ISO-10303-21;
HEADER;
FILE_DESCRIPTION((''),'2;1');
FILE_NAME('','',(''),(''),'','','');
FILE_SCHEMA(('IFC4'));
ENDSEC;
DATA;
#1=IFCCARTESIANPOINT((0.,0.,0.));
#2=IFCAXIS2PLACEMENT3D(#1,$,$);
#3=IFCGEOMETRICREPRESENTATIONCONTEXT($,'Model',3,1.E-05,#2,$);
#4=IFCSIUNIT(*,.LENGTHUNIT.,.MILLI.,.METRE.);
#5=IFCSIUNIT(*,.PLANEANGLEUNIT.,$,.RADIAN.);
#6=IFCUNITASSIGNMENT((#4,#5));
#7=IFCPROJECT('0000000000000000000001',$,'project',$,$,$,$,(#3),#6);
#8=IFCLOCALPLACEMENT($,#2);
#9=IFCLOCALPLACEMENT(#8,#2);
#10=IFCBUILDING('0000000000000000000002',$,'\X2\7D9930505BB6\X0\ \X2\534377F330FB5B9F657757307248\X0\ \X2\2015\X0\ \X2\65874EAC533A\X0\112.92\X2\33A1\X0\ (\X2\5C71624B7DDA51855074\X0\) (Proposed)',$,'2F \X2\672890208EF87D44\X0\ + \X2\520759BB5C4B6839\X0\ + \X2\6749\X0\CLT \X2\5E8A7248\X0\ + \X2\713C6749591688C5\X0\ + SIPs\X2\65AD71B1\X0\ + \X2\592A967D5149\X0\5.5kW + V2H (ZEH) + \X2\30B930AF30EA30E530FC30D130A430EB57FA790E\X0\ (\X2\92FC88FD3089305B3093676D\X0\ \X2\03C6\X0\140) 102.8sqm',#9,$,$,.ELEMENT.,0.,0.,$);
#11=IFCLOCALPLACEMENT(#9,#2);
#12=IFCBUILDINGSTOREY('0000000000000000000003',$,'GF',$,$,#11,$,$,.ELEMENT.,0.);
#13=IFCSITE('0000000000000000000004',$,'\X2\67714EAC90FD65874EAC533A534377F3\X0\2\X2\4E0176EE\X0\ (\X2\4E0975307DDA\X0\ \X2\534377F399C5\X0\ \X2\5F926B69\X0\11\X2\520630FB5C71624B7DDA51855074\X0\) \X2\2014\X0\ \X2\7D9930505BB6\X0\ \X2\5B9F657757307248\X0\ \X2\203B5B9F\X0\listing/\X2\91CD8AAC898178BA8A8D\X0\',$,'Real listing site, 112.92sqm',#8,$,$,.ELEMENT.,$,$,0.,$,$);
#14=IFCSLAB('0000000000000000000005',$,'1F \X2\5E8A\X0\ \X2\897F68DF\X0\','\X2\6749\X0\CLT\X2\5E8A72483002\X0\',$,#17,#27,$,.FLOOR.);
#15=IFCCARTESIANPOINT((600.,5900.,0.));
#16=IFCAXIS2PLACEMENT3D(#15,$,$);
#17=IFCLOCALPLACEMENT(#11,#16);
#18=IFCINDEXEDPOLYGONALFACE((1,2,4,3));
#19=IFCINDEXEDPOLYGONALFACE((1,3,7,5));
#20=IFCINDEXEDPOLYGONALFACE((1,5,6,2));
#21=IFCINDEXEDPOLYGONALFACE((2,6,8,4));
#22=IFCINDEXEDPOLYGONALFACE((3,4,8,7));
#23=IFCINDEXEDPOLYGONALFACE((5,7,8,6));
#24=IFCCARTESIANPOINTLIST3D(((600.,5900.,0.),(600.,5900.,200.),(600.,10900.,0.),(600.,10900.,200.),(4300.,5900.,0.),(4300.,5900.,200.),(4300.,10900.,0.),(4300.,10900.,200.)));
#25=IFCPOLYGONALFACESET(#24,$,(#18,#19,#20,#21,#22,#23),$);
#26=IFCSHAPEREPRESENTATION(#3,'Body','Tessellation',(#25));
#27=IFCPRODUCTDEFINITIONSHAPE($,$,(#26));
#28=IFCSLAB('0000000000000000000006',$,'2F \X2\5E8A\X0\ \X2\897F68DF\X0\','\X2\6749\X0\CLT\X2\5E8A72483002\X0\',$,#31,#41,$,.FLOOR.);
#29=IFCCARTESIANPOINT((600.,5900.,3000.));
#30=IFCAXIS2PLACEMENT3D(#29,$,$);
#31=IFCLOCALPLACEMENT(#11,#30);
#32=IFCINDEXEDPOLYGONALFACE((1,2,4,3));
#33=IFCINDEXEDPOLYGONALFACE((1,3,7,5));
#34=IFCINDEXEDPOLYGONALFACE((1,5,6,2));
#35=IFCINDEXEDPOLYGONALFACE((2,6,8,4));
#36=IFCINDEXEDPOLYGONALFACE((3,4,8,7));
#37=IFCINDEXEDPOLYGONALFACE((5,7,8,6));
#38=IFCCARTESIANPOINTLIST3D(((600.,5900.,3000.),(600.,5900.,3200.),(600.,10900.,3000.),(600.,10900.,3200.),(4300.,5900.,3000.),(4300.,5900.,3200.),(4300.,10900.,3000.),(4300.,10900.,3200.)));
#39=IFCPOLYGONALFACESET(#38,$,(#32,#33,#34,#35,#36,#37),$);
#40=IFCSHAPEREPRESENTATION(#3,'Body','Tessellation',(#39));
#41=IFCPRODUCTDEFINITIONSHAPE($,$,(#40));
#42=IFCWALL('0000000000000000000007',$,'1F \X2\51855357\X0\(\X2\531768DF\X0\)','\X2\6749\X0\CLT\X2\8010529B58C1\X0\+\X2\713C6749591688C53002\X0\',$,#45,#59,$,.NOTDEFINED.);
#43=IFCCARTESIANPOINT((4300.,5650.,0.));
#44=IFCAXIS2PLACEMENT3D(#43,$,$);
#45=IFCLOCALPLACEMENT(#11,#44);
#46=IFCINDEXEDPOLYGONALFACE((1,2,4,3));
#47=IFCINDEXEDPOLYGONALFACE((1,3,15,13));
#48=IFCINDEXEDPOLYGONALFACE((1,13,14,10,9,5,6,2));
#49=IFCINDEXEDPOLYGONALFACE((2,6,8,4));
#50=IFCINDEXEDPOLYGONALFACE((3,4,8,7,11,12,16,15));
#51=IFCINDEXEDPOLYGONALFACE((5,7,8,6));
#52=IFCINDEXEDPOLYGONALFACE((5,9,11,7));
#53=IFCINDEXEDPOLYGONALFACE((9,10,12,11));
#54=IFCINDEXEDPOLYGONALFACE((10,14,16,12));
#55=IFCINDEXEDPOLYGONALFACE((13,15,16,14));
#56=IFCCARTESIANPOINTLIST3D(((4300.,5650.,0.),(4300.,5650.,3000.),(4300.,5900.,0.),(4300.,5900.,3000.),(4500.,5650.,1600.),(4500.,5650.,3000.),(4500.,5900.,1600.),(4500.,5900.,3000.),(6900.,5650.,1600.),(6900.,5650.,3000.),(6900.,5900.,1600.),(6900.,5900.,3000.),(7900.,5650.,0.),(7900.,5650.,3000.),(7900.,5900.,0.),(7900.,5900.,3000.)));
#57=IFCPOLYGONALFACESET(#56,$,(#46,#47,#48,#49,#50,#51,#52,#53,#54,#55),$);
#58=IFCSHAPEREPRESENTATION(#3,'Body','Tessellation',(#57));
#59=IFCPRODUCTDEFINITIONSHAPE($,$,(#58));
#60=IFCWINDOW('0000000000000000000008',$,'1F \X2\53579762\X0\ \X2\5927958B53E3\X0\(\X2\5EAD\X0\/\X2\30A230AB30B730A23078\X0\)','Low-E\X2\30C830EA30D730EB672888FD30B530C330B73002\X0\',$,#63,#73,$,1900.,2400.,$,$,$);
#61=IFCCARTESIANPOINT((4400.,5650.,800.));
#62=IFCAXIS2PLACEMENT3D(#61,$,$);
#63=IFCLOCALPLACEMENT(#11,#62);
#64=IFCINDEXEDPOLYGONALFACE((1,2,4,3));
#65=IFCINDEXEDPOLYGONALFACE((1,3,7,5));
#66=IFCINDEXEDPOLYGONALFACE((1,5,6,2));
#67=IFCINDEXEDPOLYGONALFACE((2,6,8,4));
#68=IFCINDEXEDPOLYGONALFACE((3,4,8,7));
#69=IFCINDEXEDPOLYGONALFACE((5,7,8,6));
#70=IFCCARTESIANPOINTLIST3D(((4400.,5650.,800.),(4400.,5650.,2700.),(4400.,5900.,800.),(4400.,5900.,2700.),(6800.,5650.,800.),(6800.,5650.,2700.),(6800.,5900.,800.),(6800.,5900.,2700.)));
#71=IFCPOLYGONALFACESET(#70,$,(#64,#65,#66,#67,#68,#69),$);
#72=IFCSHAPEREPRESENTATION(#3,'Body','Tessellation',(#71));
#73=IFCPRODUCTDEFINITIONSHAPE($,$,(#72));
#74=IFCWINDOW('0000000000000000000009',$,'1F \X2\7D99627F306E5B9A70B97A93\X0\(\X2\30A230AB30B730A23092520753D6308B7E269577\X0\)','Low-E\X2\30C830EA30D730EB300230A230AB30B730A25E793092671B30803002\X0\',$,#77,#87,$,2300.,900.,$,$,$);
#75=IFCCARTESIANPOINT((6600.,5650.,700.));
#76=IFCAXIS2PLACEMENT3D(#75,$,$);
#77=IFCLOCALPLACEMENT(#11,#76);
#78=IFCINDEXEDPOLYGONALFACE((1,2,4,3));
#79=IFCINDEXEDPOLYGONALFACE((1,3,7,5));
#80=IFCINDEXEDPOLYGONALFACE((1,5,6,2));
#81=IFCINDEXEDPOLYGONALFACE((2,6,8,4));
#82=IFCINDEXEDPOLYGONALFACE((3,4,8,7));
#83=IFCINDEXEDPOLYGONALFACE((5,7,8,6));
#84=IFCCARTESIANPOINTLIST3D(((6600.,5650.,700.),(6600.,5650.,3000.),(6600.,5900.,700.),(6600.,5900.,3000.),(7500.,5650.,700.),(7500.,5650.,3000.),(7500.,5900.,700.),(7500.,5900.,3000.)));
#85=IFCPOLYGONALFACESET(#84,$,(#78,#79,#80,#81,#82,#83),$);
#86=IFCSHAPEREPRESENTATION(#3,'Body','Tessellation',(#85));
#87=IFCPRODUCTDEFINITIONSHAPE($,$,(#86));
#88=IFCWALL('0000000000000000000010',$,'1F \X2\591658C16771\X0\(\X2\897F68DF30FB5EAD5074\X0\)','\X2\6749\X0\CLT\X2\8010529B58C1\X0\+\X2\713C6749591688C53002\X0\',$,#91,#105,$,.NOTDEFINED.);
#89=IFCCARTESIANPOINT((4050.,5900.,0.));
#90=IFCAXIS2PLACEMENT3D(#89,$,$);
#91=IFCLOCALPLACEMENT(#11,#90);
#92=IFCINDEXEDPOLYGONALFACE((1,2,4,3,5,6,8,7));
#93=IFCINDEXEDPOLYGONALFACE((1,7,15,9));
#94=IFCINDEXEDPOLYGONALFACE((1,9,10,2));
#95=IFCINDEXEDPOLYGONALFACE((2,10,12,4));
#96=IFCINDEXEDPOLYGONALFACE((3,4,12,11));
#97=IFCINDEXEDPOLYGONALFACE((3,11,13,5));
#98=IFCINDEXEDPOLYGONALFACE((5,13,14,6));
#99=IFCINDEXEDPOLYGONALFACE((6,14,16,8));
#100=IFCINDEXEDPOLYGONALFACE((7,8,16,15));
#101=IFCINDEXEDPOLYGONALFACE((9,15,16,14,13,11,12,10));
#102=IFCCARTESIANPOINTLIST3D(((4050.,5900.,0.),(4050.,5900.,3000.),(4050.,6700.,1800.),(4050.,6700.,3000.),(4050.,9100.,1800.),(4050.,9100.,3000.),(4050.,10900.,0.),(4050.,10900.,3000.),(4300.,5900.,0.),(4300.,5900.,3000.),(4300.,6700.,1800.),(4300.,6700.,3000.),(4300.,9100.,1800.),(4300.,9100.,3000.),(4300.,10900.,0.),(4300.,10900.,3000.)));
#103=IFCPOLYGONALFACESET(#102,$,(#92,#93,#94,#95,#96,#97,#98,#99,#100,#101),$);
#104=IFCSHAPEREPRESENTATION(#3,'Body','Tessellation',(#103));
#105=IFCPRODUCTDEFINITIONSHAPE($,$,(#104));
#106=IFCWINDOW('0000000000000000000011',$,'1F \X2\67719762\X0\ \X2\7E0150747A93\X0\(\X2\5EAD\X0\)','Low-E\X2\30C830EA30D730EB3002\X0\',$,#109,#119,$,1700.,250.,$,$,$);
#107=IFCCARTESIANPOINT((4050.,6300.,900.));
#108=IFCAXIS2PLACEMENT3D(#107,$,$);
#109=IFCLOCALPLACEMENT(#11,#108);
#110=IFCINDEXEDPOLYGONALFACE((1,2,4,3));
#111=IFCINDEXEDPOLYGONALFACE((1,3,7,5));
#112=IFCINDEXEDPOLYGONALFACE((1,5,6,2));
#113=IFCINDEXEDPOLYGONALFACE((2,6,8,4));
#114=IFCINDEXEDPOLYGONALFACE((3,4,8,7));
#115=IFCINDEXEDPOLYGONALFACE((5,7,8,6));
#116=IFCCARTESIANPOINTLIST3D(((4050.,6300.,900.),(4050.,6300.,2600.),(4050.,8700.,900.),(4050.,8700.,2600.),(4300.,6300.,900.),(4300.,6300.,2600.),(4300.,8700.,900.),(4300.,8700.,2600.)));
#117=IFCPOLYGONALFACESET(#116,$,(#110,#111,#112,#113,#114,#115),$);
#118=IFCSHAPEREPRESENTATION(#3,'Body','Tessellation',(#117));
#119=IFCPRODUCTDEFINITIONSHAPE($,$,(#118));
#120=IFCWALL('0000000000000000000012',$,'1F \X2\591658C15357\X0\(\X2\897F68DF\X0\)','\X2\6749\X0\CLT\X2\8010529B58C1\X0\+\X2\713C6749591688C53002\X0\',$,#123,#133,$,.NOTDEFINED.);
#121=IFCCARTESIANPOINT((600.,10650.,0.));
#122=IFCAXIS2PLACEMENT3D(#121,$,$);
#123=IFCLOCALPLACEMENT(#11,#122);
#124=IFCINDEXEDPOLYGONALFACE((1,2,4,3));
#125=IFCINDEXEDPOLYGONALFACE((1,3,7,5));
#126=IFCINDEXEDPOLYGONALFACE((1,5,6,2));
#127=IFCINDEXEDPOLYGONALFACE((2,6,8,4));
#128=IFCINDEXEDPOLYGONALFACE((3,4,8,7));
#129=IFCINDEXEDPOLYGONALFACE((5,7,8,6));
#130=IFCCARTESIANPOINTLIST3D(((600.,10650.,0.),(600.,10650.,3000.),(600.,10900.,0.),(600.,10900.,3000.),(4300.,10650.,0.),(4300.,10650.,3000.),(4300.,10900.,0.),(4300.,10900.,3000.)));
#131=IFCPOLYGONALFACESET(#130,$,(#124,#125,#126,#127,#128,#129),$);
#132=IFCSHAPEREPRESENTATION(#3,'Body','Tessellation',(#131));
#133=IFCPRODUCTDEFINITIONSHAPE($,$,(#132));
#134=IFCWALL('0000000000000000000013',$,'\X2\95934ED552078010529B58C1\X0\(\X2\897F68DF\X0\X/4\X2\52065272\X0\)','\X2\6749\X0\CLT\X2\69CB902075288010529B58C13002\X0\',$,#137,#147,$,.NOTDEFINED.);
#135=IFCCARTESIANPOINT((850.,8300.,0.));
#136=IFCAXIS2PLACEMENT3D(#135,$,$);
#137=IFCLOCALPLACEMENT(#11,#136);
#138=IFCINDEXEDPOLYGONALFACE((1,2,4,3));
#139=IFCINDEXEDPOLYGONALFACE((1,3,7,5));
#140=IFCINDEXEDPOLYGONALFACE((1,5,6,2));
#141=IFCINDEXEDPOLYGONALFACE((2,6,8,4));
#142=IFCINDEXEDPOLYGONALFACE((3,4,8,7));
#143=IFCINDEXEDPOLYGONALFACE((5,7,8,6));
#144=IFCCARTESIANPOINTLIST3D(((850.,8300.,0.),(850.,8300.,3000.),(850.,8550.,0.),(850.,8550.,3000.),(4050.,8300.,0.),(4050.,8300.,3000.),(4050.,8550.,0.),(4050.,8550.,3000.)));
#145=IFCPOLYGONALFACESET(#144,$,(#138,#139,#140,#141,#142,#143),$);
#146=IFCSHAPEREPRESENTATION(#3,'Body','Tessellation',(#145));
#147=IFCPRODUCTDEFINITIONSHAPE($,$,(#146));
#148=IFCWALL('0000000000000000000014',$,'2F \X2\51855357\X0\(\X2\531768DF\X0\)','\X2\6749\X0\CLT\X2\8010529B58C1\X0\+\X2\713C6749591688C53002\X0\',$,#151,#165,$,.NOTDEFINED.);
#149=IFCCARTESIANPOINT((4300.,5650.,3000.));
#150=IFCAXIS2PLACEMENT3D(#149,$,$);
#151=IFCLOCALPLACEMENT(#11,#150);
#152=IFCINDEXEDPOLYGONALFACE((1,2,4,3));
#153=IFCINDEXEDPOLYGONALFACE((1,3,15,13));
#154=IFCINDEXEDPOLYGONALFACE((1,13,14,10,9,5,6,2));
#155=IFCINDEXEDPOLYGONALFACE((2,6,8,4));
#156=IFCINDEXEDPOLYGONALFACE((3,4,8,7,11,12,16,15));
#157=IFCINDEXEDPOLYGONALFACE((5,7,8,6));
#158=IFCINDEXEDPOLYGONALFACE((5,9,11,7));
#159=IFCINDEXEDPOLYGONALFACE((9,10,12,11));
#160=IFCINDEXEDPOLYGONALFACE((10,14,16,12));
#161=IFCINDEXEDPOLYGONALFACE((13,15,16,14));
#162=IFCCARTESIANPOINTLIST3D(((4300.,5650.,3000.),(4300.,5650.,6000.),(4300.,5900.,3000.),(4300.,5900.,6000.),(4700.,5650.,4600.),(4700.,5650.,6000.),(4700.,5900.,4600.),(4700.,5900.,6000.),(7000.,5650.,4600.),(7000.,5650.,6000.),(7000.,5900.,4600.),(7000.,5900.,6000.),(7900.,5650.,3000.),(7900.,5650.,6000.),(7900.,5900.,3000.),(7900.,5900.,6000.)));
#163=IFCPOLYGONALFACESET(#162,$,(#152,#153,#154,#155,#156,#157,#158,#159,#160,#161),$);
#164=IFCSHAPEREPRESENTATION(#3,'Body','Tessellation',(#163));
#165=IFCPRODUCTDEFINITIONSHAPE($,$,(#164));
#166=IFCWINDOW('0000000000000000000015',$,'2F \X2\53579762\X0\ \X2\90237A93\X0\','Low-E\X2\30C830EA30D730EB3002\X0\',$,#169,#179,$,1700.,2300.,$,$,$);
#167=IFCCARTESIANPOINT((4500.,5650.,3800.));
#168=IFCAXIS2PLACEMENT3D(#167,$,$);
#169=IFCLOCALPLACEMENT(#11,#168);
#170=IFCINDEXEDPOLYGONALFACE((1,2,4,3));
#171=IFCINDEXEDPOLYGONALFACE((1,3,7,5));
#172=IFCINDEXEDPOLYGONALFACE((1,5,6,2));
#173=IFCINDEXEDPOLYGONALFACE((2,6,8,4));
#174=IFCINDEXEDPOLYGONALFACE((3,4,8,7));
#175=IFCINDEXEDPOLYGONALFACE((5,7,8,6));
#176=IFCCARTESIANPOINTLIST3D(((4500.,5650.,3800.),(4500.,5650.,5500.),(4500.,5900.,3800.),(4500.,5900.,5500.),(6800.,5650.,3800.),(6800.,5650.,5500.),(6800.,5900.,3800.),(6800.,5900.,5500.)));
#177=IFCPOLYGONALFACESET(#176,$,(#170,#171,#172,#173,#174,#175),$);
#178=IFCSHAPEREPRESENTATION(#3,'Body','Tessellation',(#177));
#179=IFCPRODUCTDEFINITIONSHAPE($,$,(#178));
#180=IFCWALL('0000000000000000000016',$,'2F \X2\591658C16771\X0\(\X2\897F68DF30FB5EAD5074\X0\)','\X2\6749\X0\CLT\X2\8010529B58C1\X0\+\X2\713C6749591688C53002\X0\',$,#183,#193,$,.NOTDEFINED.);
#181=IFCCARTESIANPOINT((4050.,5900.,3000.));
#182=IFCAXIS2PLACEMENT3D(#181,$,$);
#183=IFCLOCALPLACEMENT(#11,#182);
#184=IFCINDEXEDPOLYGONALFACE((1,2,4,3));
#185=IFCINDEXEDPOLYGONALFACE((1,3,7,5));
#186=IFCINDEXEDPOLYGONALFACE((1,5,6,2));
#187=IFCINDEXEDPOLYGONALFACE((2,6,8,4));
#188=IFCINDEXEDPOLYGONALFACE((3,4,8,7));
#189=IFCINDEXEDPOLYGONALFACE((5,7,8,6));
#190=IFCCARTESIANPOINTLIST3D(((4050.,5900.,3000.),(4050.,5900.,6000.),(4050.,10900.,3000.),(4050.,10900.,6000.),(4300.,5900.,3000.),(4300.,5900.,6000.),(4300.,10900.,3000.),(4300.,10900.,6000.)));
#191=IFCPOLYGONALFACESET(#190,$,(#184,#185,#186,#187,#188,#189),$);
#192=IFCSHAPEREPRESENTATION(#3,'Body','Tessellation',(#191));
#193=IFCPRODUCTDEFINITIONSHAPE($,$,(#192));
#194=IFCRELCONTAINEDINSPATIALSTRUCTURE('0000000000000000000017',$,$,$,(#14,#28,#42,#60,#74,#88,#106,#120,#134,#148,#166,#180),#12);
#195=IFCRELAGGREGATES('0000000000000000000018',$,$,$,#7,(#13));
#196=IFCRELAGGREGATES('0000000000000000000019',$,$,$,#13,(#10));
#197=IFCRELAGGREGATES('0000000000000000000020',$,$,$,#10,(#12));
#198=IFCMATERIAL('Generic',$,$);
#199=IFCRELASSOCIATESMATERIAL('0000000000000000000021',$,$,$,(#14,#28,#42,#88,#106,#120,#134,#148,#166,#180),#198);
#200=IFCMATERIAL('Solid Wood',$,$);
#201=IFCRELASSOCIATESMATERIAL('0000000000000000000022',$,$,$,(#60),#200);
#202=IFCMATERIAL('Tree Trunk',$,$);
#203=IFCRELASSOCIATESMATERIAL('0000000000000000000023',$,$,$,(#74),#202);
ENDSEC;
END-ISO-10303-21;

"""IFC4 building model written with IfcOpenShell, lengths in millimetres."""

from ifc_helpers import new_model, si_unit, frame, frame_2d, origin, place, context, project, spatial, rectangle, extrude, material, element, fill, save


model = new_model("IFC4")

# Units and contexts
model_context = context("Model", 3, precision=1e-05, world=origin())
ifc_project = project(units=[si_unit("LENGTHUNIT", "METRE", prefix="MILLI"), si_unit("PLANEANGLEUNIT", "RADIAN")], contexts=[model_context])

# Site, building, storey
site_placement = place(None, origin())
site = spatial("IfcSite", under=ifc_project, at=site_placement, Name="東京都文京区千石2丁目 (三田線 千石駅 徒歩11分・山手線内側) — 継ぐ家 実敷地版 ※実listing/重説要確認", ObjectType="Real listing site, 112.92sqm", CompositionType="ELEMENT", RefElevation=0.0)
building_placement = place(site_placement, origin())
building = spatial("IfcBuilding", under=site, at=building_placement, Name="継ぐ家 千石・実敷地版 ― 文京区112.92㎡ (山手線内側) (Proposed)", ObjectType="2F 木造軸組 + 切妻屋根 + 杉CLT 床版 + 焼杉外装 + SIPs断熱 + 太陽光5.5kW + V2H (ZEH) + スクリューパイル基礎 (鋼製らせん杭 φ140) 102.8sqm", CompositionType="ELEMENT", ElevationOfRefHeight=0.0, ElevationOfTerrain=0.0)
storey_placement = place(building_placement, origin())
storey = spatial("IfcBuildingStorey", under=building, at=storey_placement, Name="GF", CompositionType="ELEMENT", Elevation=0.0)

# Shared definitions
ifc_material_1 = material(Name="Generic")

# Slabs
slab_1_placement = place(storey_placement, frame((600.0, 5900.0, 0.0)))
element("IfcSlab", 1, at=slab_1_placement, inside=storey, material=ifc_material_1, Name="1F 床 西棟", Description="杉CLT床版。", PredefinedType="FLOOR", context=model_context, shape_type="SweptSolid", body=[
    extrude(rectangle(XDim=3700.0, YDim=5000.0, at=frame_2d((1850.0, 2500.0))), frame((600.0, 5900.0, 0.0)), (0.0, 0.0, 1.0), 200.0),
])
slab_2_placement = place(storey_placement, frame((600.0, 5900.0, 3000.0)))
element("IfcSlab", 2, at=slab_2_placement, inside=storey, material=ifc_material_1, Name="2F 床 西棟", Description="杉CLT床版。", PredefinedType="FLOOR", context=model_context, shape_type="SweptSolid", body=[
    extrude(rectangle(XDim=3700.0, YDim=5000.0, at=frame_2d((1850.0, 2500.0))), frame((600.0, 5900.0, 3000.0)), (0.0, 0.0, 1.0), 200.0),
])

# Wall, openings, windows
wall_1_placement = place(storey_placement, frame((4300.0, 5650.0, 0.0)))
wall_1 = element("IfcWall", 3, at=wall_1_placement, inside=storey, material=ifc_material_1, Name="1F 内南(北棟)", Description="杉CLT耐力壁+焼杉外装。", PredefinedType="NOTDEFINED", context=model_context, shape_type="SweptSolid", body=[
    extrude(rectangle(XDim=3600.0, YDim=250.0, at=frame_2d((1800.0, 125.0))), frame((4300.0, 5650.0, 0.0)), (0.0, 0.0, 1.0), 3000.0),
])
opening_1_placement = place(storey_placement, frame((4400.0, 5650.0, 800.0)))
opening_1 = element("IfcOpeningElement", 4, at=opening_1_placement, cuts=wall_1, PredefinedType="NOTDEFINED", context=model_context, shape_type="SweptSolid", body=[
    extrude(rectangle(XDim=2400.0, YDim=250.0, at=frame_2d((1200.0, 125.0))), frame((4400.0, 5650.0, 800.0)), (0.0, 0.0, 1.0), 1900.0),
])
opening_2_placement = place(storey_placement, frame((6600.0, 5650.0, 700.0)))
opening_2 = element("IfcOpeningElement", 5, at=opening_2_placement, cuts=wall_1, PredefinedType="NOTDEFINED", context=model_context, shape_type="SweptSolid", body=[
    extrude(rectangle(XDim=900.0, YDim=250.0, at=frame_2d((450.0, 125.0))), frame((6600.0, 5650.0, 700.0)), (0.0, 0.0, 1.0), 2300.0),
])
ifc_material_2 = material(Name="Solid Wood")
window_1_placement = place(storey_placement, frame((4400.0, 5650.0, 800.0)))
window_1 = element("IfcWindow", 6, at=window_1_placement, inside=storey, material=ifc_material_2, Name="1F 南面 大開口(庭/アカシアへ)", Description="Low-Eトリプル木製サッシ。", OverallHeight=1900.0, OverallWidth=2400.0, context=model_context, shape_type="SweptSolid", body=[
    extrude(rectangle(XDim=2400.0, YDim=250.0, at=frame_2d((1200.0, 125.0))), frame((4400.0, 5650.0, 800.0)), (0.0, 0.0, 1.0), 1900.0),
])
fill(opening_1, window_1)
ifc_material_3 = material(Name="Tree Trunk")
window_2_placement = place(storey_placement, frame((6600.0, 5650.0, 700.0)))
window_2 = element("IfcWindow", 7, at=window_2_placement, inside=storey, material=ifc_material_3, Name="1F 継承の定点窓(アカシアを切取る縦長)", Description="Low-Eトリプル。アカシア幹を望む。", OverallHeight=2300.0, OverallWidth=900.0, context=model_context, shape_type="SweptSolid", body=[
    extrude(rectangle(XDim=900.0, YDim=250.0, at=frame_2d((450.0, 125.0))), frame((6600.0, 5650.0, 700.0)), (0.0, 0.0, 1.0), 2300.0),
])
fill(opening_2, window_2)

# Wall, opening, window
wall_2_placement = place(storey_placement, frame((4050.0, 5900.0, 0.0)))
wall_2 = element("IfcWall", 8, at=wall_2_placement, inside=storey, material=ifc_material_1, Name="1F 外壁東(西棟・庭側)", Description="杉CLT耐力壁+焼杉外装。", PredefinedType="NOTDEFINED", context=model_context, shape_type="SweptSolid", body=[
    extrude(rectangle(XDim=250.0, YDim=5000.0, at=frame_2d((125.0, 2500.0))), frame((4050.0, 5900.0, 0.0)), (0.0, 0.0, 1.0), 3000.0),
])
opening_3_placement = place(storey_placement, frame((4050.0, 6300.0, 900.0)))
opening_3 = element("IfcOpeningElement", 9, at=opening_3_placement, cuts=wall_2, PredefinedType="NOTDEFINED", context=model_context, shape_type="SweptSolid", body=[
    extrude(rectangle(XDim=250.0, YDim=2400.0, at=frame_2d((125.0, 1200.0))), frame((4050.0, 6300.0, 900.0)), (0.0, 0.0, 1.0), 1700.0),
])
window_3_placement = place(storey_placement, frame((4050.0, 6300.0, 900.0)))
window_3 = element("IfcWindow", 10, at=window_3_placement, inside=storey, material=ifc_material_1, Name="1F 東面 縁側窓(庭)", Description="Low-Eトリプル。", OverallHeight=1700.0, OverallWidth=250.0, context=model_context, shape_type="SweptSolid", body=[
    extrude(rectangle(XDim=250.0, YDim=2400.0, at=frame_2d((125.0, 1200.0))), frame((4050.0, 6300.0, 900.0)), (0.0, 0.0, 1.0), 1700.0),
])
fill(opening_3, window_3)

# Walls
wall_3_placement = place(storey_placement, frame((600.0, 10650.0, 0.0)))
element("IfcWall", 11, at=wall_3_placement, inside=storey, material=ifc_material_1, Name="1F 外壁南(西棟)", Description="杉CLT耐力壁+焼杉外装。", PredefinedType="NOTDEFINED", context=model_context, shape_type="SweptSolid", body=[
    extrude(rectangle(XDim=3700.0, YDim=250.0, at=frame_2d((1850.0, 125.0))), frame((600.0, 10650.0, 0.0)), (0.0, 0.0, 1.0), 3000.0),
])
wall_4_placement = place(storey_placement, frame((850.0, 8300.0, 0.0)))
element("IfcWall", 12, at=wall_4_placement, inside=storey, material=ifc_material_1, Name="間仕切耐力壁(西棟X/4分割)", Description="杉CLT構造用耐力壁。", PredefinedType="NOTDEFINED", context=model_context, shape_type="SweptSolid", body=[
    extrude(rectangle(XDim=3200.0, YDim=250.0, at=frame_2d((1600.0, 125.0))), frame((850.0, 8300.0, 0.0)), (0.0, 0.0, 1.0), 3000.0),
])

# Wall, opening, window
wall_5_placement = place(storey_placement, frame((4300.0, 5650.0, 3000.0)))
wall_5 = element("IfcWall", 13, at=wall_5_placement, inside=storey, material=ifc_material_1, Name="2F 内南(北棟)", Description="杉CLT耐力壁+焼杉外装。", PredefinedType="NOTDEFINED", context=model_context, shape_type="SweptSolid", body=[
    extrude(rectangle(XDim=3600.0, YDim=250.0, at=frame_2d((1800.0, 125.0))), frame((4300.0, 5650.0, 3000.0)), (0.0, 0.0, 1.0), 3000.0),
])
opening_4_placement = place(storey_placement, frame((4500.0, 5650.0, 3800.0)))
opening_4 = element("IfcOpeningElement", 14, at=opening_4_placement, cuts=wall_5, PredefinedType="NOTDEFINED", context=model_context, shape_type="SweptSolid", body=[
    extrude(rectangle(XDim=2300.0, YDim=250.0, at=frame_2d((1150.0, 125.0))), frame((4500.0, 5650.0, 3800.0)), (0.0, 0.0, 1.0), 1700.0),
])
window_4_placement = place(storey_placement, frame((4500.0, 5650.0, 3800.0)))
window_4 = element("IfcWindow", 15, at=window_4_placement, inside=storey, material=ifc_material_1, Name="2F 南面 連窓", Description="Low-Eトリプル。", OverallHeight=1700.0, OverallWidth=2300.0, context=model_context, shape_type="SweptSolid", body=[
    extrude(rectangle(XDim=2300.0, YDim=250.0, at=frame_2d((1150.0, 125.0))), frame((4500.0, 5650.0, 3800.0)), (0.0, 0.0, 1.0), 1700.0),
])
fill(opening_4, window_4)

# Wall
wall_6_placement = place(storey_placement, frame((4050.0, 5900.0, 3000.0)))
element("IfcWall", 16, at=wall_6_placement, inside=storey, material=ifc_material_1, Name="2F 外壁東(西棟・庭側)", Description="杉CLT耐力壁+焼杉外装。", PredefinedType="NOTDEFINED", context=model_context, shape_type="SweptSolid", body=[
    extrude(rectangle(XDim=250.0, YDim=5000.0, at=frame_2d((125.0, 2500.0))), frame((4050.0, 5900.0, 3000.0)), (0.0, 0.0, 1.0), 3000.0),
])

save(model, "model.ifc")
